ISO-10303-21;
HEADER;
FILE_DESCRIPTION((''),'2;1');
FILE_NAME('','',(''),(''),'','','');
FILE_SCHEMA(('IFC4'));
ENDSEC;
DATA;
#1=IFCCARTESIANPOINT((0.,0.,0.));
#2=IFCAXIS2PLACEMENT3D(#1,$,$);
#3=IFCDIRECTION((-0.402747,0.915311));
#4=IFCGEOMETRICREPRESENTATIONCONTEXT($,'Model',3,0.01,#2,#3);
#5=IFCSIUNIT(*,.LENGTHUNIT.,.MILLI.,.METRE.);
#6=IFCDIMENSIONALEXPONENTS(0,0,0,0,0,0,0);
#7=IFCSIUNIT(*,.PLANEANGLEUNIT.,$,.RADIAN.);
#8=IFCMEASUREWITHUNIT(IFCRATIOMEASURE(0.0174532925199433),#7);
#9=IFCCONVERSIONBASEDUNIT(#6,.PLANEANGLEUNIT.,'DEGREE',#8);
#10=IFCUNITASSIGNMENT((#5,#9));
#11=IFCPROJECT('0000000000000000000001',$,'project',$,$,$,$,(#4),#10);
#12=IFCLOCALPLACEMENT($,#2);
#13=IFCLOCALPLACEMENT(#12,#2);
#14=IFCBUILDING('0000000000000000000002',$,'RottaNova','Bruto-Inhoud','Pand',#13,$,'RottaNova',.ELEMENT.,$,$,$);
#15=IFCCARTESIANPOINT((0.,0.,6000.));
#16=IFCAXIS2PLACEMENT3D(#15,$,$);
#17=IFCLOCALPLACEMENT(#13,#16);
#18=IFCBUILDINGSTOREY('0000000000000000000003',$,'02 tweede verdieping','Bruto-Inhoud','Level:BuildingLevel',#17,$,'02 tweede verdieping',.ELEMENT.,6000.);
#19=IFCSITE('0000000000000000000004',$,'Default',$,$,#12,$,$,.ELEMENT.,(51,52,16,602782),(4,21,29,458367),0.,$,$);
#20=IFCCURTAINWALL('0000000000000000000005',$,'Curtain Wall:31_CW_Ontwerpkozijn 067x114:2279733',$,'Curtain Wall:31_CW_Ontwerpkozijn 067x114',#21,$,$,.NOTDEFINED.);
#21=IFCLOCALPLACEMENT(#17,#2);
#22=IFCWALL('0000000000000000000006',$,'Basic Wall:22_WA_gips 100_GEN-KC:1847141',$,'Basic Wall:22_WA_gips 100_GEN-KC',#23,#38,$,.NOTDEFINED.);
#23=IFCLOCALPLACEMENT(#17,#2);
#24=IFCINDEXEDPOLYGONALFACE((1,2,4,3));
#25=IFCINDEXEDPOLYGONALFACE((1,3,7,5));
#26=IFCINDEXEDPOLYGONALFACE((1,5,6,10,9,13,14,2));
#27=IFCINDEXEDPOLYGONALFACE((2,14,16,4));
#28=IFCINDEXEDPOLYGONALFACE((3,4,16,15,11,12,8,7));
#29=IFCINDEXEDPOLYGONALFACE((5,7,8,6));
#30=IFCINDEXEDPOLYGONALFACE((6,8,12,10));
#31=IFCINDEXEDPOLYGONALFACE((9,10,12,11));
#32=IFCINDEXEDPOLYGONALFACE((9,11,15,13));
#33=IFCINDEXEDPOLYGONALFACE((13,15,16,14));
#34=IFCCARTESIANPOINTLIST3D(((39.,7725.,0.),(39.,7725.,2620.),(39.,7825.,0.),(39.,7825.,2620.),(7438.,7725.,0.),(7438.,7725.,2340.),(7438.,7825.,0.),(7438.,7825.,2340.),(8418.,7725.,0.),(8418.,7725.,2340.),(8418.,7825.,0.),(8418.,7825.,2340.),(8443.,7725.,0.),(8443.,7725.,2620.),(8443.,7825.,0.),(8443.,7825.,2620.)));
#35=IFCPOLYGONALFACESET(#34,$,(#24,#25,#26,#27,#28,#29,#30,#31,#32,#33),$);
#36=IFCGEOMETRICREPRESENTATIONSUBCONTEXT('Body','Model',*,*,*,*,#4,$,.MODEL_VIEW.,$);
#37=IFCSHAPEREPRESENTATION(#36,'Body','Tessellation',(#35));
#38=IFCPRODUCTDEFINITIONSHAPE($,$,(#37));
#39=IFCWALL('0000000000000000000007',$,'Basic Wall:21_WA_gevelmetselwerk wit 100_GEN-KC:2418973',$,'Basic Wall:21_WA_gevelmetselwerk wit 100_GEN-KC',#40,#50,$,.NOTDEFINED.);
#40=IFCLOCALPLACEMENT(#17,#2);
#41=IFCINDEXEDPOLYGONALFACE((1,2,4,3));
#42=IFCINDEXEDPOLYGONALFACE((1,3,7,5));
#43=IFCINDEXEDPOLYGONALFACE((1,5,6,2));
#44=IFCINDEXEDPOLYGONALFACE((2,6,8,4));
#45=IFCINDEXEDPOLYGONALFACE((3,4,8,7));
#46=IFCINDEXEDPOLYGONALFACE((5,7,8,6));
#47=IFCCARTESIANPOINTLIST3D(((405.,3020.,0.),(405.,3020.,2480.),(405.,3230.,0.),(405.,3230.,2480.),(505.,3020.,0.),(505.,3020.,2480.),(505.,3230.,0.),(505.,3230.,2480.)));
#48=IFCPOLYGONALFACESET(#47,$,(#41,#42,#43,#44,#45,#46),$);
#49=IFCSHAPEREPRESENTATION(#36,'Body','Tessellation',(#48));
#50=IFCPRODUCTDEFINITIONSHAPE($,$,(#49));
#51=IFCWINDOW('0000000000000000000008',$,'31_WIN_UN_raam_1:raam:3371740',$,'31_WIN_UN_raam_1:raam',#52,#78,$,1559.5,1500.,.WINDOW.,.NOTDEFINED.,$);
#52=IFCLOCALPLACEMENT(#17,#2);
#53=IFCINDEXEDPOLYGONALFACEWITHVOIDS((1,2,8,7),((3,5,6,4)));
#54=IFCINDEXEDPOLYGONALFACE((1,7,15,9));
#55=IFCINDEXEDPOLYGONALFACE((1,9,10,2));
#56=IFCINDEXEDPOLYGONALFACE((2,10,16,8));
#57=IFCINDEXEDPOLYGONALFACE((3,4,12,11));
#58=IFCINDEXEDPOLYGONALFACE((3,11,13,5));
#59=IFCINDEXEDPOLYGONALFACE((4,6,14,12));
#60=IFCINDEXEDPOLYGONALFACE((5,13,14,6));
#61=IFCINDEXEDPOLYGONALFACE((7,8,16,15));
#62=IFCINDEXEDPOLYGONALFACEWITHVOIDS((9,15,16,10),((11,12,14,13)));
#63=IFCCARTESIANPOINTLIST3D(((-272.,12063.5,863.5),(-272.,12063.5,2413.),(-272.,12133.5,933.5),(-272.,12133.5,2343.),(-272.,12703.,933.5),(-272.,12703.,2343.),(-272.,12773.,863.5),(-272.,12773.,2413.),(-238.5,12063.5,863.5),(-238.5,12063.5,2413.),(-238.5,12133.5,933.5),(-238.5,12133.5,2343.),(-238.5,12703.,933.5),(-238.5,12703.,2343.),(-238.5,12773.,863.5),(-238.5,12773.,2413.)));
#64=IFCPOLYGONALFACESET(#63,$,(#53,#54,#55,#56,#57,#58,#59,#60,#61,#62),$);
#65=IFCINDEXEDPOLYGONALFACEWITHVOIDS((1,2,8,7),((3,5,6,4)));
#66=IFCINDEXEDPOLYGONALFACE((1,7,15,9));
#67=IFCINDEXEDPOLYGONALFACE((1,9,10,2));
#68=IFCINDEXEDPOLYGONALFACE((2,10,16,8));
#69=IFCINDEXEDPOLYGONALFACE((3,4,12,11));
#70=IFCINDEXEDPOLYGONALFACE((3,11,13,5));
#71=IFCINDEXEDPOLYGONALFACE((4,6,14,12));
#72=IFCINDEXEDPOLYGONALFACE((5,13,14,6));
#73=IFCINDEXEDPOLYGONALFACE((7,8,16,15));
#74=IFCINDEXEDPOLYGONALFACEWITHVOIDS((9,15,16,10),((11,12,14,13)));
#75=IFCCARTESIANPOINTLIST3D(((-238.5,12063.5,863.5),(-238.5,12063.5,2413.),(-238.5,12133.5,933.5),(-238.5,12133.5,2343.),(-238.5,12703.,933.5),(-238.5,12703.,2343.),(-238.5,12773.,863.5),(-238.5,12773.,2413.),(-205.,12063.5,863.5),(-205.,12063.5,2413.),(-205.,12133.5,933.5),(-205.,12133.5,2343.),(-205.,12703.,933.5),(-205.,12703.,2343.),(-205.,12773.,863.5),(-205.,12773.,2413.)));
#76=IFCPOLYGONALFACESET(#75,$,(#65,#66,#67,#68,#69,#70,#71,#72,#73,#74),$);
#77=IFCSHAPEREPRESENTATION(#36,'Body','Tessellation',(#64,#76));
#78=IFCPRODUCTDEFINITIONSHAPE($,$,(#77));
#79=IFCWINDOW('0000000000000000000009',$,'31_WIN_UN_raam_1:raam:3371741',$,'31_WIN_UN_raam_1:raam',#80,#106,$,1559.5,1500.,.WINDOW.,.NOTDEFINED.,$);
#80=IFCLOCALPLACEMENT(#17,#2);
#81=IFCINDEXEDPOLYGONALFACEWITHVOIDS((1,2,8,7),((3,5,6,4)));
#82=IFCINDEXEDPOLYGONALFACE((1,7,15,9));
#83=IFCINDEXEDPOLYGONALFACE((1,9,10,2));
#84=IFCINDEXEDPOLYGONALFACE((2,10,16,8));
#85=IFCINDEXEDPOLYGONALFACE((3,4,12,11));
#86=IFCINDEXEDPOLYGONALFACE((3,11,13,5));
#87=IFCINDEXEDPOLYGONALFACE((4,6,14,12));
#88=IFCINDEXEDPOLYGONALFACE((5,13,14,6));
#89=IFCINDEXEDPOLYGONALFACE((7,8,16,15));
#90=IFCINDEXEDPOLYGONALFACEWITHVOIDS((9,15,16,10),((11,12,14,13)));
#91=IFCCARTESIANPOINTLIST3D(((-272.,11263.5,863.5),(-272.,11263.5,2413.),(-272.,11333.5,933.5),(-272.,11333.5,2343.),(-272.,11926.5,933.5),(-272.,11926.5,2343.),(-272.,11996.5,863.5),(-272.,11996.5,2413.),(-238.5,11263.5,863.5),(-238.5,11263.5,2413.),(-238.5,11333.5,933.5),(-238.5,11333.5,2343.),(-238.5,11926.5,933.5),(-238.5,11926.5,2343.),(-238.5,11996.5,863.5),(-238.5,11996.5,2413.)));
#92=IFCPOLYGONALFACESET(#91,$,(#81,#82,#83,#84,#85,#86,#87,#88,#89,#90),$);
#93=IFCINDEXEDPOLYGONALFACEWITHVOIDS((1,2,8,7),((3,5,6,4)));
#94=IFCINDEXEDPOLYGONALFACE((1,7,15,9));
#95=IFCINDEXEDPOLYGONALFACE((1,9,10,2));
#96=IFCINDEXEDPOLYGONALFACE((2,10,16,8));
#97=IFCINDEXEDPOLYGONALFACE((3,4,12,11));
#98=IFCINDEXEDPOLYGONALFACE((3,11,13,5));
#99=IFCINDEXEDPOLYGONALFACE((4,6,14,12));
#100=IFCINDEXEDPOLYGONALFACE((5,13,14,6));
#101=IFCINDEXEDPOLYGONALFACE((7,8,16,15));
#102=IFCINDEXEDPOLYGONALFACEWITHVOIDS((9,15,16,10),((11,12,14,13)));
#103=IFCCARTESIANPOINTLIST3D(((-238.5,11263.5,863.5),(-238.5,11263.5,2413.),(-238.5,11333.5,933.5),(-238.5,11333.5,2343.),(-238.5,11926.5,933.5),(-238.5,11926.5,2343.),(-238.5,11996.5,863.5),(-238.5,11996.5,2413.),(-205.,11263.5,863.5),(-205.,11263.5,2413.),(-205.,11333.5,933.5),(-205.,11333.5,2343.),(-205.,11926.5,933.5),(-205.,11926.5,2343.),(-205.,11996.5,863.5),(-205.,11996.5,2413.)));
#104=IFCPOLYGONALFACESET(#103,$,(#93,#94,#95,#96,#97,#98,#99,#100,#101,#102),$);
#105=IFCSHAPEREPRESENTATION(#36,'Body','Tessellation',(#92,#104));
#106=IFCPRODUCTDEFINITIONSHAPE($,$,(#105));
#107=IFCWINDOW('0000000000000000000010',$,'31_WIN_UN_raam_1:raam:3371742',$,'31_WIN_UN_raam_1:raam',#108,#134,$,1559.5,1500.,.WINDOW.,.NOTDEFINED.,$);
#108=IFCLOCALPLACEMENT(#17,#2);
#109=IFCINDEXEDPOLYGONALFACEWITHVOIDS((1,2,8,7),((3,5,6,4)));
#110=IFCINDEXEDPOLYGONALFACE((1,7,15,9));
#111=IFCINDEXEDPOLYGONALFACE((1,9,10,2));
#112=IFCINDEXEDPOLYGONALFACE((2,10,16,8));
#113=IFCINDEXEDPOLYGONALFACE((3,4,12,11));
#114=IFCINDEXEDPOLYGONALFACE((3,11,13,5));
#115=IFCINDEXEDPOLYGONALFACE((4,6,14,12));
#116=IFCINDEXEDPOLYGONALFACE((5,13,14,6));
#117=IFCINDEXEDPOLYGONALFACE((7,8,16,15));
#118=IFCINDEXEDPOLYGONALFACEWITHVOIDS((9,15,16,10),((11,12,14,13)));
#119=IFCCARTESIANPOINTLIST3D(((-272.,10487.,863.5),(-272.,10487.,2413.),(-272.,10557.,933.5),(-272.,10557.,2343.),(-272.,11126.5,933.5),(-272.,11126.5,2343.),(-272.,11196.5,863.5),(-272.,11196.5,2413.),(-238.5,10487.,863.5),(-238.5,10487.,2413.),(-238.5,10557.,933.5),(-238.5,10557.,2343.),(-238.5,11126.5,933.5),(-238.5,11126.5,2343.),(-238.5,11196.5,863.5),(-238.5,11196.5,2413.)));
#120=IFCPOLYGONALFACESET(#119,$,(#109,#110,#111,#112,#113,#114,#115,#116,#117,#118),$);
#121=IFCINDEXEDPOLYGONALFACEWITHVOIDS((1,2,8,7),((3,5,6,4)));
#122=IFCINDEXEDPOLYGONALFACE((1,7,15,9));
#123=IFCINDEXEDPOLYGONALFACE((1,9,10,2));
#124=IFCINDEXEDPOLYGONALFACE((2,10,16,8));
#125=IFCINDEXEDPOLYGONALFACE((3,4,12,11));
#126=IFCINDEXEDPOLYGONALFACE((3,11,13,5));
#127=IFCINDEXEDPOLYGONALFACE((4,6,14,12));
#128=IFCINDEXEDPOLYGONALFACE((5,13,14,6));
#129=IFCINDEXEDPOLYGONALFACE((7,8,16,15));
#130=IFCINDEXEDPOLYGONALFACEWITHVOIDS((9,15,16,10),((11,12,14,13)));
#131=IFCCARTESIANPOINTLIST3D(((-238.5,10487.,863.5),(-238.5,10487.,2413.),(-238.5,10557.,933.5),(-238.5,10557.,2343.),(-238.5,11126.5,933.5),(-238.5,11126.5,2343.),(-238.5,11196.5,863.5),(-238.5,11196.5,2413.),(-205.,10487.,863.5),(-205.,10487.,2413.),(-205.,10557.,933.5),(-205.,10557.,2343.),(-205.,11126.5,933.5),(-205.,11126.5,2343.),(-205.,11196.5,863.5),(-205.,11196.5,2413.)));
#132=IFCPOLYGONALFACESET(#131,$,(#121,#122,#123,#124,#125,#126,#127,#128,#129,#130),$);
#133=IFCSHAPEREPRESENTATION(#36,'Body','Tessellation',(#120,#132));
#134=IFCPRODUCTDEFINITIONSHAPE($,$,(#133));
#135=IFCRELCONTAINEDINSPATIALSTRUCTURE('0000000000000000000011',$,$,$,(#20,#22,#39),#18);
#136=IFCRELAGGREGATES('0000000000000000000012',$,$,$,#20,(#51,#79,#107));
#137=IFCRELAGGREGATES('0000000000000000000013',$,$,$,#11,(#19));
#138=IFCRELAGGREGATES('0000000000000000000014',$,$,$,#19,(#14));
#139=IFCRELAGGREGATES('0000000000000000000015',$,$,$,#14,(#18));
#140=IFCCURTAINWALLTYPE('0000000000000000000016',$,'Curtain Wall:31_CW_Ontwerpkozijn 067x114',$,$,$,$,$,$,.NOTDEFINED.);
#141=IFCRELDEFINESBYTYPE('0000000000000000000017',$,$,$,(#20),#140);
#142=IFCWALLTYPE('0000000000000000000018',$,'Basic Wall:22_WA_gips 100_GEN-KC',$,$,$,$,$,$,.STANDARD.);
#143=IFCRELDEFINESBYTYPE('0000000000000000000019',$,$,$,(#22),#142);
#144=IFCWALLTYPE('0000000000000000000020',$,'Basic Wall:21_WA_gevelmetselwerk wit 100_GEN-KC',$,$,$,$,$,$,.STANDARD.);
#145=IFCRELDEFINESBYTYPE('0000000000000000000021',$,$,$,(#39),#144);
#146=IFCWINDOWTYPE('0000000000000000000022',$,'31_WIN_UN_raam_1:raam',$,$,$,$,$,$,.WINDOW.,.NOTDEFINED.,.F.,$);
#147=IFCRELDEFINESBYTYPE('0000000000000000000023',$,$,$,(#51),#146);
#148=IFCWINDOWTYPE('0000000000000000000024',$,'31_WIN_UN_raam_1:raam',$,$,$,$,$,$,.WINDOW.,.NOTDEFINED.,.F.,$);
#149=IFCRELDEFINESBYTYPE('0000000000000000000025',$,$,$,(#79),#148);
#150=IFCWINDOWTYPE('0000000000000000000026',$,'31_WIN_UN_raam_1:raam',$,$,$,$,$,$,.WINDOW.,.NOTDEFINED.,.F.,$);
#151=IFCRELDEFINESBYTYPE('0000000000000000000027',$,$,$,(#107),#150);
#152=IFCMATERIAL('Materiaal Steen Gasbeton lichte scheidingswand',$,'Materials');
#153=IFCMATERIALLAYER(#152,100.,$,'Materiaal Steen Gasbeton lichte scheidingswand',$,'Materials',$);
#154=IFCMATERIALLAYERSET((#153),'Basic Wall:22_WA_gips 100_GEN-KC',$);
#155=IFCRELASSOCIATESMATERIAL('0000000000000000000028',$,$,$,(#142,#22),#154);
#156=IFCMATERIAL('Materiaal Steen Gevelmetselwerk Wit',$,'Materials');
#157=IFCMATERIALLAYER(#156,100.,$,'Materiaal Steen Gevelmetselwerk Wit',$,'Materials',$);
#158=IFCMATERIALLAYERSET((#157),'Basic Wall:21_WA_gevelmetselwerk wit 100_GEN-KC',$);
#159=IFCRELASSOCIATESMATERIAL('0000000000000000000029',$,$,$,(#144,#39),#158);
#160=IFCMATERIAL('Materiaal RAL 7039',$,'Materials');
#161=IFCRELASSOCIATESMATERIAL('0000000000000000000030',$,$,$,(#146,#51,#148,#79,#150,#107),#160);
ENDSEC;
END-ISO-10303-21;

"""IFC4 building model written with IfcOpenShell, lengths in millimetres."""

from ifc_helpers import new_model, entity, si_unit, converted_unit, direction, frame, frame_2d, origin, place, context, subcontext, project, spatial, polyline, rectangle, outline, extrude, source, transform, mapped, material, layer, layer_set, type_object, type_shapes, element, aggregate, save


model = new_model("IFC4")

# Units and contexts
model_context = context("Model", 3, precision=0.01, world=origin(), true_north=direction((-0.402747, 0.915311)))
body_context = subcontext(model_context, "Body", "Model", "MODEL_VIEW")
ifc_project = project(units=[si_unit("LENGTHUNIT", "METRE", prefix="MILLI"), converted_unit("PLANEANGLEUNIT", "DEGREE", entity("IfcRatioMeasure", 0.0174532925199433), si_unit("PLANEANGLEUNIT", "RADIAN"), dimensions=[0, 0, 0, 0, 0, 0, 0])], contexts=[model_context])

# Site, building, storey
site_placement = place(None, origin())
site = spatial("IfcSite", under=ifc_project, at=site_placement, Name="Default", CompositionType="ELEMENT", RefLatitude=(51, 52, 16, 602782), RefLongitude=(4, 21, 29, 458367), RefElevation=0.0)
building_placement = place(site_placement, origin())
building = spatial("IfcBuilding", under=site, at=building_placement, Name="RottaNova", Description="Bruto-Inhoud", ObjectType="Pand", LongName="RottaNova", CompositionType="ELEMENT")
storey_placement = place(building_placement, frame((0.0, 0.0, 6000.0)))
storey = spatial("IfcBuildingStorey", under=building, at=storey_placement, Name="02 tweede verdieping", Description="Bruto-Inhoud", ObjectType="Level:BuildingLevel", LongName="02 tweede verdieping", CompositionType="ELEMENT", Elevation=6000.0)

# Curtain wall
curtain_wall_type = type_object("IfcCurtainWallType", Name="Curtain Wall:31_CW_Ontwerpkozijn 067x114", PredefinedType="NOTDEFINED")
curtain_wall_1_placement = place(storey_placement, frame((0.0, 0.0, -6000.0)))
curtain_wall_1 = element("IfcCurtainWall", 1, at=curtain_wall_1_placement, inside=storey, type_object=curtain_wall_type, Name="Curtain Wall:31_CW_Ontwerpkozijn 067x114:2279733", ObjectType="Curtain Wall:31_CW_Ontwerpkozijn 067x114", PredefinedType="NOTDEFINED")

# Wall, opening
ifc_material_1 = material(Name="Materiaal Steen Gasbeton lichte scheidingswand", Category="Materials")
ifc_layer_1 = layer(ifc_material_1, 100.0, Name="Materiaal Steen Gasbeton lichte scheidingswand", Category="Materials")
ifc_layer_set_1 = layer_set([ifc_layer_1], Name="Basic Wall:22_WA_gips 100_GEN-KC")
wall_type_1 = type_object("IfcWallType", Name="Basic Wall:22_WA_gips 100_GEN-KC", PredefinedType="STANDARD", material=ifc_layer_set_1)
wall_1_placement = place(storey_placement, frame((39.0, 7775.0, 0.0)))
wall_1 = element("IfcWall", 2, at=wall_1_placement, inside=storey, type_object=wall_type_1, material=ifc_layer_set_1, Name="Basic Wall:22_WA_gips 100_GEN-KC:1847141", ObjectType="Basic Wall:22_WA_gips 100_GEN-KC", PredefinedType="NOTDEFINED", context=body_context, shape_type="SweptSolid", body=[
    extrude(rectangle(XDim=8404.0, YDim=100.0, at=frame_2d((4202.0, 0.0), x_axis=(1.0, 0.0))), origin(), (0.0, 0.0, 1.0), 2620.0),
])
opening_1_placement = place(wall_1_placement, frame((8379.0, 50.0, -90.0)))
element("IfcOpeningElement", 3, at=opening_1_placement, cuts=wall_1, PredefinedType="OPENING", context=body_context, shape_type="SweptSolid", body=[
    extrude(rectangle(XDim=2430.0, YDim=980.0, at=frame_2d((1215.0, 490.0), x_axis=(1.0, 0.0))), frame((0.0, 0.0, 0.0), z_axis=(0.0, -1.0, 0.0), x_axis=(0.0, 0.0, 1.0)), (0.0, 0.0, 1.0), 100.0),
])

# Wall
ifc_material_2 = material(Name="Materiaal Steen Gevelmetselwerk Wit", Category="Materials")
ifc_layer_2 = layer(ifc_material_2, 100.0, Name="Materiaal Steen Gevelmetselwerk Wit", Category="Materials")
ifc_layer_set_2 = layer_set([ifc_layer_2], Name="Basic Wall:21_WA_gevelmetselwerk wit 100_GEN-KC")
wall_type_2 = type_object("IfcWallType", Name="Basic Wall:21_WA_gevelmetselwerk wit 100_GEN-KC", PredefinedType="STANDARD", material=ifc_layer_set_2)
wall_2_placement = place(storey_placement, frame((455.0, 3230.0, 0.0), z_axis=(0.0, 0.0, 1.0), x_axis=(0.0, -1.0, 0.0)))
element("IfcWall", 4, at=wall_2_placement, inside=storey, type_object=wall_type_2, material=ifc_layer_set_2, Name="Basic Wall:21_WA_gevelmetselwerk wit 100_GEN-KC:2418973", ObjectType="Basic Wall:21_WA_gevelmetselwerk wit 100_GEN-KC", PredefinedType="NOTDEFINED", context=body_context, shape_type="SweptSolid", body=[
    extrude(rectangle(XDim=210.0, YDim=100.0, at=frame_2d((105.0, 0.0), x_axis=(-1.0, 0.0))), origin(), (0.0, 0.0, 1.0), 2480.0),
])

# Windows
ifc_material_3 = material(Name="Materiaal RAL 7039", Category="Materials")
window_type_1 = type_object("IfcWindowType", Name="31_WIN_UN_raam_1:raam", ParameterTakesPrecedence=False, PartitioningType="NOTDEFINED", PredefinedType="WINDOW", material=ifc_material_3)
shared_shape_1 = source(origin(), body_context, "Body", "SweptSolid", [
    extrude(outline(polyline([(-354.7, -774.7), (354.7, -774.7), (354.7, 774.7), (-354.7, 774.7), (-354.7, -774.7)]), holes=[polyline([(-284.7, 704.7), (284.7, 704.7), (284.7, -704.8), (-284.7, -704.8), (-284.7, 704.7)])]), frame((0.0, 92.0, 774.8), z_axis=(0.0, -1.0, 0.0), x_axis=(-1.0, 0.0, 0.0)), (0.0, 0.0, 1.0), 33.5),
    extrude(outline(polyline([(-354.7, -774.7), (354.7, -774.7), (354.7, 774.7), (-354.7, 774.7), (-354.7, -774.7)]), holes=[polyline([(-284.7, 704.7), (284.7, 704.7), (284.7, -704.8), (-284.7, -704.8), (-284.7, 704.7)])]), frame((0.0, 58.5, 774.8), z_axis=(0.0, -1.0, 0.0), x_axis=(-1.0, 0.0, 0.0)), (0.0, 0.0, 1.0), 33.5),
])
type_shapes(window_type_1, [shared_shape_1])
window_1_placement = place(curtain_wall_1_placement, frame((-180.0, 12418.2, 6863.5), z_axis=(0.0, 0.0, 1.0), x_axis=(0.0, 1.0, 0.0)))
window_1 = element("IfcWindow", 5, at=window_1_placement, type_object=window_type_1, material=ifc_material_3, Name="31_WIN_UN_raam_1:raam:3371740", ObjectType="31_WIN_UN_raam_1:raam", OverallHeight=1559.5, OverallWidth=1500.0, PartitioningType="NOTDEFINED", PredefinedType="WINDOW", context=body_context, shape_type="MappedRepresentation", body=[
    mapped(shared_shape_1, transform((0.0, 0.0, 0.0), scale=1.0)),
])
window_type_2 = type_object("IfcWindowType", Name="31_WIN_UN_raam_1:raam", ParameterTakesPrecedence=False, PartitioningType="NOTDEFINED", PredefinedType="WINDOW", material=ifc_material_3)
shared_shape_2 = source(origin(), body_context, "Body", "SweptSolid", [
    extrude(outline(polyline([(-366.5, -774.7), (366.5, -774.7), (366.5, 774.7), (-366.5, 774.7), (-366.5, -774.7)]), holes=[polyline([(-296.5, 704.7), (296.5, 704.7), (296.5, -704.8), (-296.5, -704.8), (-296.5, 704.7)])]), frame((0.0, 92.0, 774.8), z_axis=(0.0, -1.0, 0.0), x_axis=(-1.0, 0.0, 0.0)), (0.0, 0.0, 1.0), 33.5),
    extrude(outline(polyline([(-366.5, -774.7), (366.5, -774.7), (366.5, 774.7), (-366.5, 774.7), (-366.5, -774.7)]), holes=[polyline([(-296.5, 704.7), (296.5, 704.7), (296.5, -704.8), (-296.5, -704.8), (-296.5, 704.7)])]), frame((0.0, 58.5, 774.8), z_axis=(0.0, -1.0, 0.0), x_axis=(-1.0, 0.0, 0.0)), (0.0, 0.0, 1.0), 33.5),
])
type_shapes(window_type_2, [shared_shape_2])
window_2_placement = place(curtain_wall_1_placement, frame((-180.0, 11630.0, 6863.5), z_axis=(0.0, 0.0, 1.0), x_axis=(0.0, 1.0, 0.0)))
window_2 = element("IfcWindow", 6, at=window_2_placement, type_object=window_type_2, material=ifc_material_3, Name="31_WIN_UN_raam_1:raam:3371741", ObjectType="31_WIN_UN_raam_1:raam", OverallHeight=1559.5, OverallWidth=1500.0, PartitioningType="NOTDEFINED", PredefinedType="WINDOW", context=body_context, shape_type="MappedRepresentation", body=[
    mapped(shared_shape_2, transform((0.0, 0.0, 0.0), scale=1.0)),
])
window_type_3 = type_object("IfcWindowType", Name="31_WIN_UN_raam_1:raam", ParameterTakesPrecedence=False, PartitioningType="NOTDEFINED", PredefinedType="WINDOW", material=ifc_material_3)
shared_shape_3 = source(origin(), body_context, "Body", "SweptSolid", [
    extrude(outline(polyline([(-354.7, -774.7), (354.7, -774.7), (354.7, 774.7), (-354.7, 774.7), (-354.7, -774.7)]), holes=[polyline([(-284.7, 704.7), (284.7, 704.7), (284.7, -704.8), (-284.7, -704.8), (-284.7, 704.7)])]), frame((0.0, 92.0, 774.8), z_axis=(0.0, -1.0, 0.0), x_axis=(-1.0, 0.0, 0.0)), (0.0, 0.0, 1.0), 33.5),
    extrude(outline(polyline([(-354.7, -774.7), (354.7, -774.7), (354.7, 774.7), (-354.7, 774.7), (-354.7, -774.7)]), holes=[polyline([(-284.7, 704.7), (284.7, 704.7), (284.7, -704.8), (-284.7, -704.8), (-284.7, 704.7)])]), frame((0.0, 58.5, 774.8), z_axis=(0.0, -1.0, 0.0), x_axis=(-1.0, 0.0, 0.0)), (0.0, 0.0, 1.0), 33.5),
])
type_shapes(window_type_3, [shared_shape_3])
window_3_placement = place(curtain_wall_1_placement, frame((-180.0, 10841.7, 6863.5), z_axis=(0.0, 0.0, 1.0), x_axis=(0.0, 1.0, 0.0)))
window_3 = element("IfcWindow", 7, at=window_3_placement, type_object=window_type_3, material=ifc_material_3, Name="31_WIN_UN_raam_1:raam:3371742", ObjectType="31_WIN_UN_raam_1:raam", OverallHeight=1559.5, OverallWidth=1500.0, PartitioningType="NOTDEFINED", PredefinedType="WINDOW", context=body_context, shape_type="MappedRepresentation", body=[
    mapped(shared_shape_3, transform((0.0, 0.0, 0.0), scale=1.0)),
])
aggregate(curtain_wall_1, [window_1, window_2, window_3])

save(model, "model.ifc")
